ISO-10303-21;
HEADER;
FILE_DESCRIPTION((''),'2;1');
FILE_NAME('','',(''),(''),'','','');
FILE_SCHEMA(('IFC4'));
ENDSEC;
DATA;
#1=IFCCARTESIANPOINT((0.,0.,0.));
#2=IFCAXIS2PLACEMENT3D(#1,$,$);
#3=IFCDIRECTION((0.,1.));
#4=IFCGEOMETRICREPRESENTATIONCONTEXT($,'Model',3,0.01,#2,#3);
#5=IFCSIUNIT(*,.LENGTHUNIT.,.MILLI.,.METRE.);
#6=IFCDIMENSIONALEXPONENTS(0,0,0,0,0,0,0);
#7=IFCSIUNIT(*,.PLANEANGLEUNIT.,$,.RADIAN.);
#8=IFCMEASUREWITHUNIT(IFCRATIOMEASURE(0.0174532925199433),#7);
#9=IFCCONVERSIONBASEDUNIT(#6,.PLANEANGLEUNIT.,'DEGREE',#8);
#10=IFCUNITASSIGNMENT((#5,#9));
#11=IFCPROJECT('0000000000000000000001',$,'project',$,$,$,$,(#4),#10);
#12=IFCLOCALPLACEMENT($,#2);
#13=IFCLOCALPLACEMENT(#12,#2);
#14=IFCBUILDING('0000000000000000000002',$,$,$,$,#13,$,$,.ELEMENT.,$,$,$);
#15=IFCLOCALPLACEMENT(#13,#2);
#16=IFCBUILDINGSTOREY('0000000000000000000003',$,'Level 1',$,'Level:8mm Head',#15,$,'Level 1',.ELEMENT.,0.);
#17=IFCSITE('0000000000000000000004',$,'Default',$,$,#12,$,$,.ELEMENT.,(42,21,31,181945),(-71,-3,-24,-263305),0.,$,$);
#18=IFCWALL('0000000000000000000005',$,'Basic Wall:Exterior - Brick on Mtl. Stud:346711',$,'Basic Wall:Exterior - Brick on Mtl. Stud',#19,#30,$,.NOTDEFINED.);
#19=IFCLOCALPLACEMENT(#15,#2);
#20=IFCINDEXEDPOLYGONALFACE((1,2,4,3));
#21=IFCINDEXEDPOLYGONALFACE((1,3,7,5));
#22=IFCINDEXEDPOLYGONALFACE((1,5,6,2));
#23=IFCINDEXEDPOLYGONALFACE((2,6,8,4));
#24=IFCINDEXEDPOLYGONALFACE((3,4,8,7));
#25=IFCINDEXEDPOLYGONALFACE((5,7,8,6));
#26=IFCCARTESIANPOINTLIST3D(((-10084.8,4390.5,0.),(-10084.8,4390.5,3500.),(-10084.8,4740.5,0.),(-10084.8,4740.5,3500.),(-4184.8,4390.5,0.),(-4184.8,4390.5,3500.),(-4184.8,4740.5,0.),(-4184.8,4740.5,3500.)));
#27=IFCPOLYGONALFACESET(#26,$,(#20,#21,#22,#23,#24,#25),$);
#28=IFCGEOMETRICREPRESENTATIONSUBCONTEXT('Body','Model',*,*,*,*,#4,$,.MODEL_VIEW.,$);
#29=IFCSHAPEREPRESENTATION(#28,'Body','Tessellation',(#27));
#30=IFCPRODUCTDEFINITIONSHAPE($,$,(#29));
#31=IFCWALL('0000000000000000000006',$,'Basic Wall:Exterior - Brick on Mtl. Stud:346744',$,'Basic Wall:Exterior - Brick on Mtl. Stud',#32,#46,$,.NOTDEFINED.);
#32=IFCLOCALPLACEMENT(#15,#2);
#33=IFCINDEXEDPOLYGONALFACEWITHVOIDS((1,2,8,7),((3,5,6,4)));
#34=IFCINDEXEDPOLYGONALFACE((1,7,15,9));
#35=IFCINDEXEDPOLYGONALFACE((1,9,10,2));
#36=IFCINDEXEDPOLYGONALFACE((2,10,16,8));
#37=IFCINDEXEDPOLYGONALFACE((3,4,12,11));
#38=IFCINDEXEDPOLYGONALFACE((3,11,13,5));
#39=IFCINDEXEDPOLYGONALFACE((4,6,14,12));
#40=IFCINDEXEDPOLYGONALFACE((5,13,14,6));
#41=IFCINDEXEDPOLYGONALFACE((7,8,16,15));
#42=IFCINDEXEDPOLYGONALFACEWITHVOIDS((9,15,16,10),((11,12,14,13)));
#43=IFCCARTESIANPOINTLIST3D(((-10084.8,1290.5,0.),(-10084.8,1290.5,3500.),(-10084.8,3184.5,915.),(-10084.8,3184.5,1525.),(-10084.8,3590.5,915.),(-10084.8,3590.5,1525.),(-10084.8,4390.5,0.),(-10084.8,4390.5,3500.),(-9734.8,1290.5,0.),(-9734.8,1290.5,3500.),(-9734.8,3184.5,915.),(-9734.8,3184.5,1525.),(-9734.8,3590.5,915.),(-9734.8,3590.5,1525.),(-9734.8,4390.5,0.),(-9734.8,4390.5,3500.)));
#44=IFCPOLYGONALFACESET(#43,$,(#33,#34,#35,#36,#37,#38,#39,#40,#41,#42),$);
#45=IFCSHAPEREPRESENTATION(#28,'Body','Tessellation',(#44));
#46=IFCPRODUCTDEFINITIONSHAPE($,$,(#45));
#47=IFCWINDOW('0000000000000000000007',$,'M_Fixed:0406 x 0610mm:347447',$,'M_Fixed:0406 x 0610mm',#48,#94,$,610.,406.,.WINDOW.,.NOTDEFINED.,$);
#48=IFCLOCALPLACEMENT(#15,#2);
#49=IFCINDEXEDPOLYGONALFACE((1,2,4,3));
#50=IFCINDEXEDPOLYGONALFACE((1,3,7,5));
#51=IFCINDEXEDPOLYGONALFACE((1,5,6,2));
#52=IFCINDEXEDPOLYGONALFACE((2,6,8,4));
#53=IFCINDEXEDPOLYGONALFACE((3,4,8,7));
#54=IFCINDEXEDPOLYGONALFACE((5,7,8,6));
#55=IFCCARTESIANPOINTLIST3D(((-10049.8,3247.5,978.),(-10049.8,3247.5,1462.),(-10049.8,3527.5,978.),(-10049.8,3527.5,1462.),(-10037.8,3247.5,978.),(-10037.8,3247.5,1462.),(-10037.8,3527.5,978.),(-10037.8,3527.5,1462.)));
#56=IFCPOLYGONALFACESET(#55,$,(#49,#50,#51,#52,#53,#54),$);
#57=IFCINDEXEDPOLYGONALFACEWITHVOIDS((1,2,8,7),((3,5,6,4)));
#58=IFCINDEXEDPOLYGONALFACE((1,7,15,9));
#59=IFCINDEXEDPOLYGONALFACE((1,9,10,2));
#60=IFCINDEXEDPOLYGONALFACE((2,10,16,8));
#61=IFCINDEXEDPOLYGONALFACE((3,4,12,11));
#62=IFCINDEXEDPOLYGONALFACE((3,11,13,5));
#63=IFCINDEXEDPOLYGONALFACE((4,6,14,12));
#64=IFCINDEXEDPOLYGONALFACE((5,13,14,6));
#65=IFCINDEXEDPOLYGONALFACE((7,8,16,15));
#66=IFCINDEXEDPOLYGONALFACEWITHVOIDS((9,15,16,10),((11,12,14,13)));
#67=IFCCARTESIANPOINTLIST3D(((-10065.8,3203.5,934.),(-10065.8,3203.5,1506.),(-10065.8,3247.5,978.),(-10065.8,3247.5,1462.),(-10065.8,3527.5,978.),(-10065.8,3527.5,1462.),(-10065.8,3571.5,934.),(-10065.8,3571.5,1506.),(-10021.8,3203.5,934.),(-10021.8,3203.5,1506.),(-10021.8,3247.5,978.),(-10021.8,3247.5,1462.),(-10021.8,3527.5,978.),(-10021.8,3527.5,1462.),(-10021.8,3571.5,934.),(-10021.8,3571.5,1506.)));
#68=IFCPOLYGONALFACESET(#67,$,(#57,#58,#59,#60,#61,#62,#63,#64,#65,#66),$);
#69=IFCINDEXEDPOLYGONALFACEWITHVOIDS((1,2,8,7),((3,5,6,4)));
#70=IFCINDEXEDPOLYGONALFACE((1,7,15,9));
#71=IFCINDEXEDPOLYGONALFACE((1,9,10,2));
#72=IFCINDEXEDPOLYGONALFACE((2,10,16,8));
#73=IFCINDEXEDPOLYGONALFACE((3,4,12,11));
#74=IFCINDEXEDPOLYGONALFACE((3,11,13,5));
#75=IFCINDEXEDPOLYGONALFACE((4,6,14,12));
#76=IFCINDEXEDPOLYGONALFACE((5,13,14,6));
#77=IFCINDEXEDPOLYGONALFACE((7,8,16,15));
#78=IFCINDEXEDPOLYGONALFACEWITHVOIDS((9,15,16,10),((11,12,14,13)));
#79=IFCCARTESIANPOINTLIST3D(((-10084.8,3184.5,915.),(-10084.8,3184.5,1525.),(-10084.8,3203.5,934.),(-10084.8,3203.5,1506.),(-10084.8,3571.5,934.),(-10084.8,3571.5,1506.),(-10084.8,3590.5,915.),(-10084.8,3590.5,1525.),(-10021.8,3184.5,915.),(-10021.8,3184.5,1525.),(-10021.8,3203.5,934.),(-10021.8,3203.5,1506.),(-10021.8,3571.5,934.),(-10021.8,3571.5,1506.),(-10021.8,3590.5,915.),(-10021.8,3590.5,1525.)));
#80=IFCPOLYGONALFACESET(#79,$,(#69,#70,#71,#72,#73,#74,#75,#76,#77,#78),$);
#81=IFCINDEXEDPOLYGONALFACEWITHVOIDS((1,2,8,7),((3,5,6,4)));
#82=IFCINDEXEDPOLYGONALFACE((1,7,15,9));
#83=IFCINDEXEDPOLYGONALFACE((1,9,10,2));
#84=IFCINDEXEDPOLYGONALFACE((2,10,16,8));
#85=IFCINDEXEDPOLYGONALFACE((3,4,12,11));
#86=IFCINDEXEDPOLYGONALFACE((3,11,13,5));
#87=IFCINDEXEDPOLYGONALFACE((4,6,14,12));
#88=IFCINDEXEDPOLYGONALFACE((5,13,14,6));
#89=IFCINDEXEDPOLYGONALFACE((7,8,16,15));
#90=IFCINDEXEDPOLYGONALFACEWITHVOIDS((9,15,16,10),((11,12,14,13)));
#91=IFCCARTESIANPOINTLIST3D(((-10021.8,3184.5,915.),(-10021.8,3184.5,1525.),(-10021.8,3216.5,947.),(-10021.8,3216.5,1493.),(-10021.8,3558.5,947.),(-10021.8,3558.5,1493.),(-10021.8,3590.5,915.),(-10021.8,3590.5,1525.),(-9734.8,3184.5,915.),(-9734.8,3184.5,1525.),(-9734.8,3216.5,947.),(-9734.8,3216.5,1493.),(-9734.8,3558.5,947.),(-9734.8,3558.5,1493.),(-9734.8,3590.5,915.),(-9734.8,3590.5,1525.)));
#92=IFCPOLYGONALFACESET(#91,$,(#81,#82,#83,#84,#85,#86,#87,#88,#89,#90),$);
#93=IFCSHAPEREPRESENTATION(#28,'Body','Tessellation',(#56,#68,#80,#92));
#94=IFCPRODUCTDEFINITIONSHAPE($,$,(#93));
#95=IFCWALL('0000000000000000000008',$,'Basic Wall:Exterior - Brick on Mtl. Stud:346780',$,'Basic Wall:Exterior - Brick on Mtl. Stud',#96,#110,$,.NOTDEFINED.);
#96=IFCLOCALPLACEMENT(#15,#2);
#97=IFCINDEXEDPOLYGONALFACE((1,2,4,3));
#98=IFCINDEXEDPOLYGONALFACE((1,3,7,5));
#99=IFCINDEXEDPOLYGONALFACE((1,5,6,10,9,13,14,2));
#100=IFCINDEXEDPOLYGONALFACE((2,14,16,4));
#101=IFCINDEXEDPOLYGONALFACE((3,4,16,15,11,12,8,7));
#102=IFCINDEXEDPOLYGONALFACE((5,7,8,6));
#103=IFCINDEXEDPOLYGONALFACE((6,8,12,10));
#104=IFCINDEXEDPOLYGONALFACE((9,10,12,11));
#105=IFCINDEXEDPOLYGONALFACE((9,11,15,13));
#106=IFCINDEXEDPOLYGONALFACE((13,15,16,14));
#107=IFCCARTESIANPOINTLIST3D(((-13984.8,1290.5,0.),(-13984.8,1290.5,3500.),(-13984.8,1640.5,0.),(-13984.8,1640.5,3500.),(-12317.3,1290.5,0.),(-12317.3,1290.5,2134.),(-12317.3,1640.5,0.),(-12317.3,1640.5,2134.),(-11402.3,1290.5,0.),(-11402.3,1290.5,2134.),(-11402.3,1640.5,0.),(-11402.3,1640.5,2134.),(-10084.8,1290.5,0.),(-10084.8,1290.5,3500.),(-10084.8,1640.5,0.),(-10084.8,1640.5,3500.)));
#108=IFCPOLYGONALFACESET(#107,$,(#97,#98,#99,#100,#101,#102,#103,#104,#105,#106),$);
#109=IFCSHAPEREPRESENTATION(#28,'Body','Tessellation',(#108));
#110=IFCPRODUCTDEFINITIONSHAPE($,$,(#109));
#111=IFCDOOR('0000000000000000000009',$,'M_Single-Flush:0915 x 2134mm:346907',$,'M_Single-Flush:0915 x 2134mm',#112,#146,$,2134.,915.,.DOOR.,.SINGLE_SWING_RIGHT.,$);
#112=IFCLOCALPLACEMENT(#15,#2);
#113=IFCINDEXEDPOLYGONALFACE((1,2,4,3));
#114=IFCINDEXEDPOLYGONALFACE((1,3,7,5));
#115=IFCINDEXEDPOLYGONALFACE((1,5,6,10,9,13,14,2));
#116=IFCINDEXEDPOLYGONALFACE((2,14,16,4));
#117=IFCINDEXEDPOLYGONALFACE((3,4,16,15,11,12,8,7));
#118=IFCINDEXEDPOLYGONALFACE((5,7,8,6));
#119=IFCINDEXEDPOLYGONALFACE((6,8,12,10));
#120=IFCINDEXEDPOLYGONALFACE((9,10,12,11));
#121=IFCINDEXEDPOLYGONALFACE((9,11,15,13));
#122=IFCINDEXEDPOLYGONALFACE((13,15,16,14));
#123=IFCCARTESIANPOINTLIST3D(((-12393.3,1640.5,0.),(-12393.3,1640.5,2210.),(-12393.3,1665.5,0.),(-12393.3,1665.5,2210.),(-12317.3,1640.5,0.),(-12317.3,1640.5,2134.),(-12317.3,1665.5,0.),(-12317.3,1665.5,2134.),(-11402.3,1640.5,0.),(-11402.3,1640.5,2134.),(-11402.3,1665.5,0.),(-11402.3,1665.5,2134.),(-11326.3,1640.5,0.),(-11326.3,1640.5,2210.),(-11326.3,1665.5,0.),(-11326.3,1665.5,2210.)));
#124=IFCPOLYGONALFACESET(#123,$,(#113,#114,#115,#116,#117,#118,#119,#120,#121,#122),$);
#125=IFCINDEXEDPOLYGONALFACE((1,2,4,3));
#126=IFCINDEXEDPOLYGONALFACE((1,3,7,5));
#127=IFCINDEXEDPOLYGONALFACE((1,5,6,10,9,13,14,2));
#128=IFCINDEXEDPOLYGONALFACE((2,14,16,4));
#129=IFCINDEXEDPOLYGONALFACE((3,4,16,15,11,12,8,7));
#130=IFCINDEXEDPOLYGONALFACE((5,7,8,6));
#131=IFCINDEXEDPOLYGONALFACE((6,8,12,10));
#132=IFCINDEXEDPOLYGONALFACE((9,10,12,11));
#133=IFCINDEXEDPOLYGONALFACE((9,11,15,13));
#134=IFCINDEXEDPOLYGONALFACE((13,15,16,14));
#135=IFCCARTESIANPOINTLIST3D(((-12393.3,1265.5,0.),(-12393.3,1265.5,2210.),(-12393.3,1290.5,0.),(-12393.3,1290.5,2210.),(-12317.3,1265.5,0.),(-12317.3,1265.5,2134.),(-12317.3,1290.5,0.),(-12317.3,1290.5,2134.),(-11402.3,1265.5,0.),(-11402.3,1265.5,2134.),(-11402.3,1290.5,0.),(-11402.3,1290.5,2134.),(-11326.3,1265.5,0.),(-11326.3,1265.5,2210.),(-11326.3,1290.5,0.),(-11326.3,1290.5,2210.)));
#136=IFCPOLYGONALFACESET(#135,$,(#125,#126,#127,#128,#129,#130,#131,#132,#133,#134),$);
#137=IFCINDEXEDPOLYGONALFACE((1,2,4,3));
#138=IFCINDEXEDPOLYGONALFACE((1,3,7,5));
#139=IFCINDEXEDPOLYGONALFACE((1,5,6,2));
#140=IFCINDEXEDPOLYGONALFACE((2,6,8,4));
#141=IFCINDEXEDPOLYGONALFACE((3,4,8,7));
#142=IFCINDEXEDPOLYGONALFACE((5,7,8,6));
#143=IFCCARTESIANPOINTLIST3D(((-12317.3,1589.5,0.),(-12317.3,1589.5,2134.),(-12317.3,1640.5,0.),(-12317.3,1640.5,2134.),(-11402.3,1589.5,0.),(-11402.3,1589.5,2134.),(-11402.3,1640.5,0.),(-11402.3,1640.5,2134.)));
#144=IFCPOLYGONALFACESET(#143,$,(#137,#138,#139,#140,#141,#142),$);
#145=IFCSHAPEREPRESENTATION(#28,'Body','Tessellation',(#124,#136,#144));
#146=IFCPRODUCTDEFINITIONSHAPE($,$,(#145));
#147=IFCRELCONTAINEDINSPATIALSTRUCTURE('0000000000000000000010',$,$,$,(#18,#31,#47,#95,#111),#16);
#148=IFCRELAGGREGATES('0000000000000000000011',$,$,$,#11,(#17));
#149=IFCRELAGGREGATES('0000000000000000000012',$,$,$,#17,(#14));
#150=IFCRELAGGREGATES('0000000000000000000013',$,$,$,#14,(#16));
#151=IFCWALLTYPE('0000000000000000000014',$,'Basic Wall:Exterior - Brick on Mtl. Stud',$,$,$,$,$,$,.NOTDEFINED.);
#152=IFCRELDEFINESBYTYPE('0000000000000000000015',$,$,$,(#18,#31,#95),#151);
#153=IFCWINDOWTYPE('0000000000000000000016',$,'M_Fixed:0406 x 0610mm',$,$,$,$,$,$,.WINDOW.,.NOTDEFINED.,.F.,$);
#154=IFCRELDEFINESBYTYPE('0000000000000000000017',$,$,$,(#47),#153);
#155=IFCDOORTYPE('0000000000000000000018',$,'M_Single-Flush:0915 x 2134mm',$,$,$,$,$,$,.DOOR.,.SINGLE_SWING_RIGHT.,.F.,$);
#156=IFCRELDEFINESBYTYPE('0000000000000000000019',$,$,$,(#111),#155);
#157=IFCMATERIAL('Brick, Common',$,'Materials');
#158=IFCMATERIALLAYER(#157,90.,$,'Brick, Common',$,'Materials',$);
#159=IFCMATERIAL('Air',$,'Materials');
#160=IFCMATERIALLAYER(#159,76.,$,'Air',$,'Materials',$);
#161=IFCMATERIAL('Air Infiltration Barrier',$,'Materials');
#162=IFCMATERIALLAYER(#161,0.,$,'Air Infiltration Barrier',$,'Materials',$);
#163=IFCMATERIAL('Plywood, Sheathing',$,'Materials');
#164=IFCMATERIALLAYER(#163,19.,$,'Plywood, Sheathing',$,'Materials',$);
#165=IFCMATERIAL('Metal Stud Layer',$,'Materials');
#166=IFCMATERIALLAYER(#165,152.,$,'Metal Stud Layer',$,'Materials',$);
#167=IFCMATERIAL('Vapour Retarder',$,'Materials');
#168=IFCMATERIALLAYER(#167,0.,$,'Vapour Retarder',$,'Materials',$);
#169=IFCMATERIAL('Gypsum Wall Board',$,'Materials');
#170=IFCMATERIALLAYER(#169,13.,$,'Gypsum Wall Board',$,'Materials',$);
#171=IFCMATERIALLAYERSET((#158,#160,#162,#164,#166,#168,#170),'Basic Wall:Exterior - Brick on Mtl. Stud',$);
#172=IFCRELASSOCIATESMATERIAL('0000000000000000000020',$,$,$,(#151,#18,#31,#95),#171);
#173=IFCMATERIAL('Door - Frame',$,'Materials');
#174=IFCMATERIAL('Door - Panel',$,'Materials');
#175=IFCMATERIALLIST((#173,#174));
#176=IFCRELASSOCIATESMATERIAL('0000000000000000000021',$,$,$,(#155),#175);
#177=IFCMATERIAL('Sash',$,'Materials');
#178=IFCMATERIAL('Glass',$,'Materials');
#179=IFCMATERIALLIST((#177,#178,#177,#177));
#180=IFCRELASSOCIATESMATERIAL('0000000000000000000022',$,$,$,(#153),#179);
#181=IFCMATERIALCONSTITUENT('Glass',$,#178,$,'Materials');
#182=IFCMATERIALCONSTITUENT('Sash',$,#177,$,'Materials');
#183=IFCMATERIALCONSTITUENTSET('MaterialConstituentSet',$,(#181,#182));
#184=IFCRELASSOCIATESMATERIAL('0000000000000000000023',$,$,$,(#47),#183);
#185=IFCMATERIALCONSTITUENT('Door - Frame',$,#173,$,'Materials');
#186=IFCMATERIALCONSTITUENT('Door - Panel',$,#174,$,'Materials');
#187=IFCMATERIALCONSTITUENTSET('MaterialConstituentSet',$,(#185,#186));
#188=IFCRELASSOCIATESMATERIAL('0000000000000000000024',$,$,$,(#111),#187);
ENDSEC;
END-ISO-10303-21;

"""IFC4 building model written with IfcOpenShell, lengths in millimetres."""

from ifc_helpers import new_model, entity, si_unit, converted_unit, direction, frame, frame_2d, origin, place, context, subcontext, project, spatial, polyline, rectangle, outline, extrude, source, transform, mapped, material, material_list, layer, layer_set, layer_usage, constituent, constituent_set, type_object, type_shapes, element, fill, save


model = new_model("IFC4")

# Units and contexts
model_context = context("Model", 3, precision=0.01, world=origin(), true_north=direction((0.0, 1.0)))
body_context = subcontext(model_context, "Body", "Model", "MODEL_VIEW")
ifc_project = project(units=[si_unit("LENGTHUNIT", "METRE", prefix="MILLI"), converted_unit("PLANEANGLEUNIT", "DEGREE", entity("IfcRatioMeasure", 0.0174532925199433), si_unit("PLANEANGLEUNIT", "RADIAN"), dimensions=[0, 0, 0, 0, 0, 0, 0])], contexts=[model_context])

# Site, building, storey
site_placement = place(None, origin())
site = spatial("IfcSite", under=ifc_project, at=site_placement, Name="Default", CompositionType="ELEMENT", RefLatitude=(42, 21, 31, 181945), RefLongitude=(-71, -3, -24, -263305), RefElevation=0.0)
building_placement = place(site_placement, origin())
building = spatial("IfcBuilding", under=site, at=building_placement, CompositionType="ELEMENT")
storey_placement = place(building_placement, origin())
storey = spatial("IfcBuildingStorey", under=building, at=storey_placement, Name="Level 1", ObjectType="Level:8mm Head", LongName="Level 1", CompositionType="ELEMENT", Elevation=0.0)

# Shared definitions
ifc_material_1 = material(Name="Brick, Common", Category="Materials")
ifc_layer_1 = layer(ifc_material_1, 90.0, Name="Brick, Common", Category="Materials")
ifc_material_2 = material(Name="Air", Category="Materials")
ifc_layer_2 = layer(ifc_material_2, 76.0, Name="Air", Category="Materials")
ifc_material_3 = material(Name="Air Infiltration Barrier", Category="Materials")
ifc_layer_3 = layer(ifc_material_3, 0.0, Name="Air Infiltration Barrier", Category="Materials")
ifc_material_4 = material(Name="Plywood, Sheathing", Category="Materials")
ifc_layer_4 = layer(ifc_material_4, 19.0, Name="Plywood, Sheathing", Category="Materials")
ifc_material_5 = material(Name="Metal Stud Layer", Category="Materials")
ifc_layer_5 = layer(ifc_material_5, 152.0, Name="Metal Stud Layer", Category="Materials")
ifc_material_6 = material(Name="Vapour Retarder", Category="Materials")
ifc_layer_6 = layer(ifc_material_6, 0.0, Name="Vapour Retarder", Category="Materials")
ifc_material_7 = material(Name="Gypsum Wall Board", Category="Materials")
ifc_layer_7 = layer(ifc_material_7, 13.0, Name="Gypsum Wall Board", Category="Materials")
ifc_layer_set_1 = layer_set([ifc_layer_1, ifc_layer_2, ifc_layer_3, ifc_layer_4, ifc_layer_5, ifc_layer_6, ifc_layer_7], Name="Basic Wall:Exterior - Brick on Mtl. Stud")
wall_type_1 = type_object("IfcWallType", Name="Basic Wall:Exterior - Brick on Mtl. Stud", PredefinedType="NOTDEFINED", material=ifc_layer_set_1)
ifc_material_8 = material(Name="Door - Frame", Category="Materials")
ifc_material_9 = material(Name="Door - Panel", Category="Materials")
ifc_material_list_1 = material_list([ifc_material_8, ifc_material_9])
door_type_1 = type_object("IfcDoorType", Name="M_Single-Flush:0915 x 2134mm", OperationType="SINGLE_SWING_RIGHT", ParameterTakesPrecedence=False, PredefinedType="DOOR", material=ifc_material_list_1)
shared_shape_1 = source(origin(), body_context, "Body", "SweptSolid", [
    extrude(outline(polyline([(-533.5, -1124.0), (533.5, -1124.0), (533.5, 1086.0), (457.5, 1086.0), (457.5, -1048.0), (-457.5, -1048.0), (-457.5, 1086.0), (-533.5, 1086.0), (-533.5, -1124.0)])), frame((457.5, 350.0, 1086.0), z_axis=(0.0, 1.0, 0.0), x_axis=(1.0, 0.0, 0.0)), (0.0, 0.0, 1.0), 25.0),
    extrude(outline(polyline([(-1124.0, -533.5), (1086.0, -533.5), (1086.0, -457.5), (-1048.0, -457.5), (-1048.0, 457.5), (1086.0, 457.5), (1086.0, 533.5), (-1124.0, 533.5), (-1124.0, -533.5)])), frame((457.5, -25.0, 1086.0), z_axis=(0.0, 1.0, 0.0), x_axis=(0.0, 0.0, -1.0)), (0.0, 0.0, 1.0), 25.0),
    extrude(rectangle(XDim=51.0, YDim=915.0, at=frame_2d((0.0, 0.0), x_axis=(1.0, 0.0))), frame((457.5, 324.5, 0.0), z_axis=(0.0, 0.0, 1.0), x_axis=(0.0, 1.0, 0.0)), (0.0, 0.0, 1.0), 2134.0),
])
type_shapes(door_type_1, [shared_shape_1])
ifc_material_10 = material(Name="Glass", Category="Materials")
ifc_material_11 = material(Name="Sash", Category="Materials")

# Wall
ifc_layer_usage_1 = layer_usage(ifc_layer_set_1, "AXIS2", "NEGATIVE", 175.0)
wall_1_placement = place(storey_placement, frame((-4184.8, 4565.5, 0.0), z_axis=(0.0, 0.0, 1.0), x_axis=(-1.0, 0.0, 0.0)))
element("IfcWall", 1, at=wall_1_placement, inside=storey, type_object=wall_type_1, material=ifc_layer_usage_1, Name="Basic Wall:Exterior - Brick on Mtl. Stud:346711", ObjectType="Basic Wall:Exterior - Brick on Mtl. Stud", PredefinedType="NOTDEFINED", context=body_context, shape_type="SweptSolid", body=[
    extrude(rectangle(XDim=5900.0, YDim=350.0, at=frame_2d((2950.0, 0.0), x_axis=(-1.0, 0.0))), origin(), (0.0, 0.0, 1.0), 3500.0),
])

# Wall, opening, window
ifc_layer_usage_2 = layer_usage(ifc_layer_set_1, "AXIS2", "NEGATIVE", 175.0)
wall_2_placement = place(storey_placement, frame((-9909.8, 4390.5, 0.0), z_axis=(0.0, 0.0, 1.0), x_axis=(0.0, -1.0, 0.0)))
wall_2 = element("IfcWall", 2, at=wall_2_placement, inside=storey, type_object=wall_type_1, material=ifc_layer_usage_2, Name="Basic Wall:Exterior - Brick on Mtl. Stud:346744", ObjectType="Basic Wall:Exterior - Brick on Mtl. Stud", PredefinedType="NOTDEFINED", context=body_context, shape_type="SweptSolid", body=[
    extrude(rectangle(XDim=3100.0, YDim=350.0, at=frame_2d((1550.0, 0.0), x_axis=(-1.0, 0.0))), origin(), (0.0, 0.0, 1.0), 3500.0),
])
opening_1_placement = place(wall_2_placement, frame((1206.0, 175.0, 915.0)))
opening_1 = element("IfcOpeningElement", 3, at=opening_1_placement, cuts=wall_2, ObjectType="Opening", PredefinedType="OPENING", context=body_context, shape_type="SweptSolid", body=[
    extrude(rectangle(XDim=610.0, YDim=406.0, at=frame_2d((305.0, 203.0), x_axis=(1.0, 0.0))), frame((0.0, 0.0, 0.0), z_axis=(0.0, -1.0, 0.0), x_axis=(0.0, 0.0, 1.0)), (0.0, 0.0, 1.0), 350.0),
])
ifc_constituent_1 = constituent(ifc_material_10, Name="Glass", Category="Materials")
ifc_constituent_2 = constituent(ifc_material_11, Name="Sash", Category="Materials")
ifc_constituent_set_1 = constituent_set(constituents=[ifc_constituent_1, ifc_constituent_2], Name="MaterialConstituentSet")
ifc_material_list_2 = material_list([ifc_material_11, ifc_material_10, ifc_material_11, ifc_material_11])
window_type_1 = type_object("IfcWindowType", Name="M_Fixed:0406 x 0610mm", ParameterTakesPrecedence=False, PartitioningType="NOTDEFINED", PredefinedType="WINDOW", material=ifc_material_list_2)
shared_shape_2 = source(origin(), body_context, "Body", "SweptSolid", [
    extrude(rectangle(XDim=280.0, YDim=12.0, at=frame_2d((0.0, 0.0), x_axis=(1.0, 0.0))), frame((203.0, 335.0, 63.0), z_axis=(0.0, 0.0, 1.0), x_axis=(-1.0, 0.0, 0.0)), (0.0, 0.0, 1.0), 484.0),
    extrude(outline(polyline([(-184.0, -286.0), (184.0, -286.0), (184.0, 286.0), (-184.0, 286.0), (-184.0, -286.0)]), holes=[polyline([(-140.0, -242.0), (-140.0, 242.0), (140.0, 242.0), (140.0, -242.0), (-140.0, -242.0)])]), frame((203.0, 357.0, 305.0), z_axis=(0.0, -1.0, 0.0), x_axis=(-1.0, 0.0, 0.0)), (0.0, 0.0, 1.0), 44.0),
    extrude(outline(polyline([(-203.0, -305.0), (203.0, -305.0), (203.0, 305.0), (-203.0, 305.0), (-203.0, -305.0)]), holes=[polyline([(-184.0, -286.0), (-184.0, 286.0), (184.0, 286.0), (184.0, -286.0), (-184.0, -286.0)])]), frame((203.0, 376.0, 305.0), z_axis=(0.0, -1.0, 0.0), x_axis=(-1.0, 0.0, 0.0)), (0.0, 0.0, 1.0), 63.0),
    extrude(outline(polyline([(-203.0, -305.0), (203.0, -305.0), (203.0, 305.0), (-203.0, 305.0), (-203.0, -305.0)]), holes=[polyline([(-171.0, -273.0), (-171.0, 273.0), (171.0, 273.0), (171.0, -273.0), (-171.0, -273.0)])]), frame((203.0, 313.0, 305.0), z_axis=(0.0, -1.0, 0.0), x_axis=(-1.0, 0.0, 0.0)), (0.0, 0.0, 1.0), 287.0),
])
type_shapes(window_type_1, [shared_shape_2])
window_1_placement = place(opening_1_placement, frame((0.0, 26.0, 0.0), z_axis=(0.0, 0.0, 1.0), x_axis=(-1.0, 0.0, 0.0)))
window_1 = element("IfcWindow", 4, at=window_1_placement, inside=storey, type_object=window_type_1, material=ifc_constituent_set_1, Name="M_Fixed:0406 x 0610mm:347447", ObjectType="M_Fixed:0406 x 0610mm", OverallHeight=610.0, OverallWidth=406.0, PartitioningType="NOTDEFINED", PredefinedType="WINDOW", context=body_context, shape_type="MappedRepresentation", body=[
    mapped(shared_shape_2, transform((0.0, 0.0, 0.0), scale=1.0)),
])
fill(opening_1, window_1)

# Wall, opening, door
ifc_layer_usage_3 = layer_usage(ifc_layer_set_1, "AXIS2", "NEGATIVE", 175.0)
wall_3_placement = place(storey_placement, frame((-10084.8, 1465.5, 0.0), z_axis=(0.0, 0.0, 1.0), x_axis=(-1.0, 0.0, 0.0)))
wall_3 = element("IfcWall", 5, at=wall_3_placement, inside=storey, type_object=wall_type_1, material=ifc_layer_usage_3, Name="Basic Wall:Exterior - Brick on Mtl. Stud:346780", ObjectType="Basic Wall:Exterior - Brick on Mtl. Stud", PredefinedType="NOTDEFINED", context=body_context, shape_type="SweptSolid", body=[
    extrude(rectangle(XDim=3900.0, YDim=350.0, at=frame_2d((1950.0, 0.0), x_axis=(-1.0, 0.0))), origin(), (0.0, 0.0, 1.0), 3500.0),
])
opening_2_placement = place(wall_3_placement, frame((2232.5, 175.0, 0.0)))
opening_2 = element("IfcOpeningElement", 6, at=opening_2_placement, cuts=wall_3, ObjectType="Opening", PredefinedType="OPENING", context=body_context, shape_type="SweptSolid", body=[
    extrude(rectangle(XDim=915.0, YDim=2134.0, at=frame_2d((1067.0, 457.5), x_axis=(0.0, 1.0))), frame((0.0, 0.0, 0.0), z_axis=(0.0, -1.0, 0.0), x_axis=(0.0, 0.0, 1.0)), (0.0, 0.0, 1.0), 350.0),
])
ifc_constituent_3 = constituent(ifc_material_8, Name="Door - Frame", Category="Materials")
ifc_constituent_4 = constituent(ifc_material_9, Name="Door - Panel", Category="Materials")
ifc_constituent_set_2 = constituent_set(constituents=[ifc_constituent_3, ifc_constituent_4], Name="MaterialConstituentSet")
door_1_placement = place(opening_2_placement, frame((0.0, 0.0, 0.0), z_axis=(0.0, 0.0, 1.0), x_axis=(-1.0, 0.0, 0.0)))
door_1 = element("IfcDoor", 7, at=door_1_placement, inside=storey, type_object=door_type_1, material=ifc_constituent_set_2, Name="M_Single-Flush:0915 x 2134mm:346907", ObjectType="M_Single-Flush:0915 x 2134mm", OperationType="SINGLE_SWING_RIGHT", OverallHeight=2134.0, OverallWidth=915.0, PredefinedType="DOOR", context=body_context, shape_type="MappedRepresentation", body=[
    mapped(shared_shape_1, transform((0.0, 0.0, 0.0), scale=1.0)),
])
fill(opening_2, door_1)

save(model, "model.ifc")
